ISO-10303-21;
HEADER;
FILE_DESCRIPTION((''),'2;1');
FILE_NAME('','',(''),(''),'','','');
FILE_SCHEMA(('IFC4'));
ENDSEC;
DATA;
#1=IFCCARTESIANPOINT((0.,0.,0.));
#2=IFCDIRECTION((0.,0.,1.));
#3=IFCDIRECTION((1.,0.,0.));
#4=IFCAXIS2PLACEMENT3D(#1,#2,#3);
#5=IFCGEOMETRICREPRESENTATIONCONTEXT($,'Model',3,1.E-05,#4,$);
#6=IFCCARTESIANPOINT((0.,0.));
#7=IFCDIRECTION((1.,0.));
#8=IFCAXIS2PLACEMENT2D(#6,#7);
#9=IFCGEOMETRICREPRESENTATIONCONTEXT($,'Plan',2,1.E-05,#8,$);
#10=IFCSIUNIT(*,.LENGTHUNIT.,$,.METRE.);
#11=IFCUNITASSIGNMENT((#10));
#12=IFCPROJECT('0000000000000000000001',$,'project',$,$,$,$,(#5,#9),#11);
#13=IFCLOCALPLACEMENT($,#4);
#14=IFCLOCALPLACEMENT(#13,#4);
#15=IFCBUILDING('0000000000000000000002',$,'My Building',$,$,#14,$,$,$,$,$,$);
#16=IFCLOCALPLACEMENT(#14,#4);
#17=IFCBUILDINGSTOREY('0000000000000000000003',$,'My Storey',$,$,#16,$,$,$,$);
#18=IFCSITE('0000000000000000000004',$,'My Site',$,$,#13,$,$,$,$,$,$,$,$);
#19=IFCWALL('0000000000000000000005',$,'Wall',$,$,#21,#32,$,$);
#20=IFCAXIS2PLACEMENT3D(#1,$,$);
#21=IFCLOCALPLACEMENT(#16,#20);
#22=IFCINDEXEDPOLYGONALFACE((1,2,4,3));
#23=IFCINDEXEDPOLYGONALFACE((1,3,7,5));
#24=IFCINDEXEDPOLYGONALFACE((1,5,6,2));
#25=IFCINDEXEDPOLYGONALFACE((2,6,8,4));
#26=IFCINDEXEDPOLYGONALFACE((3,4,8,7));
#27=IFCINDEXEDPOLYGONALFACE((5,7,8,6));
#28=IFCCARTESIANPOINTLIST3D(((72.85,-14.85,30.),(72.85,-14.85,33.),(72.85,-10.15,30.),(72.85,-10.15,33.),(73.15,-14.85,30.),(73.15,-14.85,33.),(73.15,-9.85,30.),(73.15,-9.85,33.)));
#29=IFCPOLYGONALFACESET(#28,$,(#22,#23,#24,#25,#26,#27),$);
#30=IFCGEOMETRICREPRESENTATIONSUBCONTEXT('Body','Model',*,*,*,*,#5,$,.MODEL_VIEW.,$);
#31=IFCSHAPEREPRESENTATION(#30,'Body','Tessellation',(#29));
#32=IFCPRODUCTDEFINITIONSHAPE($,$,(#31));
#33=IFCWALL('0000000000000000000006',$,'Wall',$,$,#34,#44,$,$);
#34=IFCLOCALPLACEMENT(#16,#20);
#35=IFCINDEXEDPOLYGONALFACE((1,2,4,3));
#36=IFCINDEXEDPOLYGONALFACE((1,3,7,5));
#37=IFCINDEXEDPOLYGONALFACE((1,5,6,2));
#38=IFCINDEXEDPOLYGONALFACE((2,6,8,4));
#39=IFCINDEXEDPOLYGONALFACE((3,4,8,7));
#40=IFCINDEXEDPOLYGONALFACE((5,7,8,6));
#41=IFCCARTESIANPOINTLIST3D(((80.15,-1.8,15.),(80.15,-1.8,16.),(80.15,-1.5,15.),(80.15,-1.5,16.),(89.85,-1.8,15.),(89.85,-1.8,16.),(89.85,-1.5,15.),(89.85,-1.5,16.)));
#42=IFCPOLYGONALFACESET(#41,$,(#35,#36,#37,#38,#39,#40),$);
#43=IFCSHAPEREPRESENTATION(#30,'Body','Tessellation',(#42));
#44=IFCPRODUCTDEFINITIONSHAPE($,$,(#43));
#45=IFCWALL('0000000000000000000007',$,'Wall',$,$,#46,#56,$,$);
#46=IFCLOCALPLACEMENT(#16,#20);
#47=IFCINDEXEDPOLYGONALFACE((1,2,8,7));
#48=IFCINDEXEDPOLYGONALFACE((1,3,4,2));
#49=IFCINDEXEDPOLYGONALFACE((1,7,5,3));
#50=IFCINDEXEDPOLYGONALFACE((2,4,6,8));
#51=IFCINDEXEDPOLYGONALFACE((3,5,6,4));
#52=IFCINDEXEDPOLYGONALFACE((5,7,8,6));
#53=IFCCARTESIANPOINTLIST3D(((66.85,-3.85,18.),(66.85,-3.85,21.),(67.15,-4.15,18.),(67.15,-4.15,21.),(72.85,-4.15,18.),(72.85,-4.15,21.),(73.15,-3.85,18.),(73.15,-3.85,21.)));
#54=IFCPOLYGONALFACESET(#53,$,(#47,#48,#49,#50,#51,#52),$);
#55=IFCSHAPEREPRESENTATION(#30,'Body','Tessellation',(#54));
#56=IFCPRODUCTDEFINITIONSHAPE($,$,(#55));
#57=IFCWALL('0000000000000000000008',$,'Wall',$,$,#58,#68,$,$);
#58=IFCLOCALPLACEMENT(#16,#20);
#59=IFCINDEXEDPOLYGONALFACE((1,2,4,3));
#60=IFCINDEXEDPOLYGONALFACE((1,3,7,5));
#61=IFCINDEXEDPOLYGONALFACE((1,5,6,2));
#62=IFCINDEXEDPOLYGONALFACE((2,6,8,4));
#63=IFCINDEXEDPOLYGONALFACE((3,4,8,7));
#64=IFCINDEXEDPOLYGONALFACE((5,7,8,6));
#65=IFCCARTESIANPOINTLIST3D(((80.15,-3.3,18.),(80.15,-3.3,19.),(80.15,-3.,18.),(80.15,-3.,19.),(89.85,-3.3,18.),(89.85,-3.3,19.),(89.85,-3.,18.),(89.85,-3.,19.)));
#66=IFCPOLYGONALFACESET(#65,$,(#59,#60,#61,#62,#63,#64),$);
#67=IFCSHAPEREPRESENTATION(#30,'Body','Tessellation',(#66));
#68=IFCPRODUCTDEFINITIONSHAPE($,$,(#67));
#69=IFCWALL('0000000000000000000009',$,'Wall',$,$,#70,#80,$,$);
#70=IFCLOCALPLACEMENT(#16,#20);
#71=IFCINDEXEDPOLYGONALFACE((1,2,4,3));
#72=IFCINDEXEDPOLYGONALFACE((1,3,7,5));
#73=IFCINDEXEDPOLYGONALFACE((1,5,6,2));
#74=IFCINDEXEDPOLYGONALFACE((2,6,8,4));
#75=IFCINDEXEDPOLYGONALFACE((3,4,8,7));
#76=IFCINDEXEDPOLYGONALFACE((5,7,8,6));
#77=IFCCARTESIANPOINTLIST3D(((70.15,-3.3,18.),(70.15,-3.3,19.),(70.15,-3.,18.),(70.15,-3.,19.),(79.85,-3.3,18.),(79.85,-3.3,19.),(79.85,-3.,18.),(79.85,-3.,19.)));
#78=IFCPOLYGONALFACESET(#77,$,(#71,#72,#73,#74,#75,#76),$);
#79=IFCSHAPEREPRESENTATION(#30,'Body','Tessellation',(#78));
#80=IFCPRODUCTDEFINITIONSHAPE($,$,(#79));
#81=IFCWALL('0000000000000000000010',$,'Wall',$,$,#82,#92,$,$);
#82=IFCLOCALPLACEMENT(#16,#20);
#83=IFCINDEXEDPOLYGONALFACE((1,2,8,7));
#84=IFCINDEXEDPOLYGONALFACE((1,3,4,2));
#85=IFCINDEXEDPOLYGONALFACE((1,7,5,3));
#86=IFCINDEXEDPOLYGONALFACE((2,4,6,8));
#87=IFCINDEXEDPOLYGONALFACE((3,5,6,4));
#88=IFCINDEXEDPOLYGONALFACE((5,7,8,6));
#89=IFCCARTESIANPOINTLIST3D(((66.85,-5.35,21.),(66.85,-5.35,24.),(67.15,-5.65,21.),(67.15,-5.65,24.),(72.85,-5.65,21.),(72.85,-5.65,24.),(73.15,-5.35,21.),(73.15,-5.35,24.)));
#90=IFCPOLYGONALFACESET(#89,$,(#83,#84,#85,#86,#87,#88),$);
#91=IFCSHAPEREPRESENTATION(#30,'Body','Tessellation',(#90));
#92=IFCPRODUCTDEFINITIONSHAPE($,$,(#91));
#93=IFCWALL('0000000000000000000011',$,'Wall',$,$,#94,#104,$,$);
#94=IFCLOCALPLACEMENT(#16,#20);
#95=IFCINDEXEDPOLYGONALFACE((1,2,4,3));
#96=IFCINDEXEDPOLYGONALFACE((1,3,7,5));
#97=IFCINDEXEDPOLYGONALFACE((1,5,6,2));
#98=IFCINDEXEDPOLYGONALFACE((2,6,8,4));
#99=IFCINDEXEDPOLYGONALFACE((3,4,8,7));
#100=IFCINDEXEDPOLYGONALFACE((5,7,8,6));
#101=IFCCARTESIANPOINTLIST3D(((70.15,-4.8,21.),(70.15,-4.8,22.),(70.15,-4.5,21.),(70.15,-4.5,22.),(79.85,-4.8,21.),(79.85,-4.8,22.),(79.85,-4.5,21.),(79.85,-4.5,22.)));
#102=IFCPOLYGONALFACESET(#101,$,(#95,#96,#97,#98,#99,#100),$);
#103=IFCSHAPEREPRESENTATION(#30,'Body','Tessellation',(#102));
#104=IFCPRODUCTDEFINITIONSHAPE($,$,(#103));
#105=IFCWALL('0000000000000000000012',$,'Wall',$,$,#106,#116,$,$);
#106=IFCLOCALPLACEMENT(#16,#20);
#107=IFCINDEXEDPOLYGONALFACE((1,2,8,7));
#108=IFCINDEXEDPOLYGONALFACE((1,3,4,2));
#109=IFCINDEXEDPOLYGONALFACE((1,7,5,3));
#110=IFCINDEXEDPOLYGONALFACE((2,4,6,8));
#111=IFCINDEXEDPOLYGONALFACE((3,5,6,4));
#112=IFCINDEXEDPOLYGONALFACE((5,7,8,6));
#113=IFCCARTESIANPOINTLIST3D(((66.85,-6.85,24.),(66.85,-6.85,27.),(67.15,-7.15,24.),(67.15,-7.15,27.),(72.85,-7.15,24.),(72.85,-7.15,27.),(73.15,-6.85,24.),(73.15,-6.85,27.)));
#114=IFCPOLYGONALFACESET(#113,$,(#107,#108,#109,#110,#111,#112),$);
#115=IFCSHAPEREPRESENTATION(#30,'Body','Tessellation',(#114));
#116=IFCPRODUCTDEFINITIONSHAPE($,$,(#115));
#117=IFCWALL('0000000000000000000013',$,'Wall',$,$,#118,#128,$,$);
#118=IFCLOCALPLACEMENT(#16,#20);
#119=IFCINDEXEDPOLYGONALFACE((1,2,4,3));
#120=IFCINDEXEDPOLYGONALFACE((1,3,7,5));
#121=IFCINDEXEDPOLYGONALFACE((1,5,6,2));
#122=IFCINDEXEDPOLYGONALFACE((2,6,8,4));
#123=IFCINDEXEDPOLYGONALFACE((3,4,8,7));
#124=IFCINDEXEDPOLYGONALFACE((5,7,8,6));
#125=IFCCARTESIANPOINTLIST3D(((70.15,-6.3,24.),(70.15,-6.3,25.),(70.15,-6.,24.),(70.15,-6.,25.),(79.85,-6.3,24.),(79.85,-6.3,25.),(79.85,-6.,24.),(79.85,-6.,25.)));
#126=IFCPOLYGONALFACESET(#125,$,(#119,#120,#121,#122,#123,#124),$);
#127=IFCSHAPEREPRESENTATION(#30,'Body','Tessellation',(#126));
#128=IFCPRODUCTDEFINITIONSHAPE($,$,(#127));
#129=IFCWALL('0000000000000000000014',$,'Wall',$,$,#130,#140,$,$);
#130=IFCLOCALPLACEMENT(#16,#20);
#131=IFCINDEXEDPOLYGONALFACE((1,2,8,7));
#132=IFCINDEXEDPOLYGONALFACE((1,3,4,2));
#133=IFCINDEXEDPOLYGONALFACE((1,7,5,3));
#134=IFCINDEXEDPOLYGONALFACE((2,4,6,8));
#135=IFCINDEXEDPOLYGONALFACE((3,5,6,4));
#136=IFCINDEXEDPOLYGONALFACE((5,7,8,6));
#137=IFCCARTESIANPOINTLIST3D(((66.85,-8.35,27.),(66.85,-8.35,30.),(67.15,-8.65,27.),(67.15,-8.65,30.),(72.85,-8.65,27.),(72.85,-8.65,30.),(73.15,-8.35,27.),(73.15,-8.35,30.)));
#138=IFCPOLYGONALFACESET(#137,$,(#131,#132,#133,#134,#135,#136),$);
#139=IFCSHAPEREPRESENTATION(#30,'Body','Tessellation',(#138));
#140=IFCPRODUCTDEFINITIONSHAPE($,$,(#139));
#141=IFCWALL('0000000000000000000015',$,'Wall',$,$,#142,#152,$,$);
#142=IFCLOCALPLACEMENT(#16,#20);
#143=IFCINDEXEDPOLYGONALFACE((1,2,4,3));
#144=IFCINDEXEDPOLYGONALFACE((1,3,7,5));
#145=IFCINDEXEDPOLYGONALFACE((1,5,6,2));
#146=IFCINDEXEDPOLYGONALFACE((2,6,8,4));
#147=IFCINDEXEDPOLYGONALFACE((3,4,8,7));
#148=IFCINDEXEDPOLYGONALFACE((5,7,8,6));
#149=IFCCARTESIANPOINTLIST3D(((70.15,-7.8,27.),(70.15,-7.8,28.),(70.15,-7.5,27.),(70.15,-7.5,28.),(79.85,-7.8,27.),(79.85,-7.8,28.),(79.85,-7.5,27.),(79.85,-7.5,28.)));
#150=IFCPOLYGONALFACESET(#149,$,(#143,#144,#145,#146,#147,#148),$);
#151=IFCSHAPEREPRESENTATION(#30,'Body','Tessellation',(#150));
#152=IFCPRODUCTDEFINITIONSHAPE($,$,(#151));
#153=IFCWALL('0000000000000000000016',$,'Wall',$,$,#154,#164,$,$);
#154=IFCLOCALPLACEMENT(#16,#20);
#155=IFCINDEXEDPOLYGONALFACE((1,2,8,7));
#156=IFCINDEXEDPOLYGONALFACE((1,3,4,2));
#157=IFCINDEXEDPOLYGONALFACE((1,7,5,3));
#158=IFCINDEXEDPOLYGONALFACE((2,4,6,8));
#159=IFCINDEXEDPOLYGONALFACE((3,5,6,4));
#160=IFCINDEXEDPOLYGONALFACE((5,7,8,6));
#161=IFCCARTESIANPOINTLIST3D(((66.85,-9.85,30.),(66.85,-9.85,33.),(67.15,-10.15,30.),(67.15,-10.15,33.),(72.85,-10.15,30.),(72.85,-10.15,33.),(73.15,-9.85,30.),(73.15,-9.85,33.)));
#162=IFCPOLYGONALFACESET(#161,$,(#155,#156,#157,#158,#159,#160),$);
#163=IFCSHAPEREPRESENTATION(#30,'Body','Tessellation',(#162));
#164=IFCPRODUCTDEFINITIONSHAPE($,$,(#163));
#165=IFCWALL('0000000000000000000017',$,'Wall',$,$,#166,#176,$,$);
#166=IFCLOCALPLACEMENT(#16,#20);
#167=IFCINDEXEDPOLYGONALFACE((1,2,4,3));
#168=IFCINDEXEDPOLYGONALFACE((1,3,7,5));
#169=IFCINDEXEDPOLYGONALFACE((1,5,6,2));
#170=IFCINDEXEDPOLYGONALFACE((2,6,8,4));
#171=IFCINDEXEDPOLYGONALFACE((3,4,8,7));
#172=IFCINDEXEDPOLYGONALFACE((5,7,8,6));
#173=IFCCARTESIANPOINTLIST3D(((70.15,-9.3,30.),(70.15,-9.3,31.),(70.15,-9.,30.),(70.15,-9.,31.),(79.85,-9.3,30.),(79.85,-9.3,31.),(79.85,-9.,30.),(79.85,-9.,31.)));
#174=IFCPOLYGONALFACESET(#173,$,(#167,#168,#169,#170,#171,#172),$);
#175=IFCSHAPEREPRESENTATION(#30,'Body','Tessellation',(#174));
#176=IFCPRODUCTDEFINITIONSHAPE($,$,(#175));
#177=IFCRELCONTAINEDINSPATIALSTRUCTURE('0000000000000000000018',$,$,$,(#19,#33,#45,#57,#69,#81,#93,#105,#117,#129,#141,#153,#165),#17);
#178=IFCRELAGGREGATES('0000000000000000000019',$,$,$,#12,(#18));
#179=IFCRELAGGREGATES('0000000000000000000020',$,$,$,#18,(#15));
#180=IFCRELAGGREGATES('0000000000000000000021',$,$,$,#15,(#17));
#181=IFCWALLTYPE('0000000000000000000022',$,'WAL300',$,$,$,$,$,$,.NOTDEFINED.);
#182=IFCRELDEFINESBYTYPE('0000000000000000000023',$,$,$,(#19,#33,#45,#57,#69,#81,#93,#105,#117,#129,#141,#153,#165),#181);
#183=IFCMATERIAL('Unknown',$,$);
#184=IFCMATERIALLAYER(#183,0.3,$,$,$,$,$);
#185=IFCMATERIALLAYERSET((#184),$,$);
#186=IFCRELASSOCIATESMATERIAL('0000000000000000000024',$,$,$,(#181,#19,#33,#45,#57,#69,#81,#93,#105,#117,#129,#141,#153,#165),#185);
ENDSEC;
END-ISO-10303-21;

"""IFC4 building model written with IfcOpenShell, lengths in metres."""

from ifc_helpers import new_model, si_unit, frame, origin_with_axes, origin_2d_with_axis, place, context, subcontext, project, spatial, line, indexed_curve, outline, extrude, material, layer, layer_set, layer_usage, type_object, element, save


model = new_model("IFC4")

# Units and contexts
model_context = context("Model", 3, precision=1e-05, world=origin_with_axes())
plan_context = context("Plan", 2, precision=1e-05, world=origin_2d_with_axis())
body_context = subcontext(model_context, "Body", "Model", "MODEL_VIEW")
ifc_project = project(units=[si_unit("LENGTHUNIT", "METRE")], contexts=[model_context, plan_context])

# Site, building, storey
site_placement = place(None, origin_with_axes())
site = spatial("IfcSite", under=ifc_project, at=site_placement, Name="My Site")
building_placement = place(site_placement, origin_with_axes())
building = spatial("IfcBuilding", under=site, at=building_placement, Name="My Building")
storey_placement = place(building_placement, origin_with_axes())
storey = spatial("IfcBuildingStorey", under=building, at=storey_placement, Name="My Storey")

# Walls
ifc_material = material(Name="Unknown")
ifc_layer = layer(ifc_material, 0.3)
ifc_layer_set = layer_set([ifc_layer])
wall_type = type_object("IfcWallType", Name="WAL300", PredefinedType="NOTDEFINED", material=ifc_layer_set)
ifc_layer_usage_1 = layer_usage(ifc_layer_set, "AXIS2", "POSITIVE", -0.15)
wall_1_placement = place(storey_placement, frame((73.0, -15.0, 30.0), z_axis=(0.0, 0.0, 1.0), x_axis=(0.0, 1.0, 0.0)))
element("IfcWall", 1, at=wall_1_placement, inside=storey, type_object=wall_type, material=ifc_layer_usage_1, Name="Wall", context=body_context, shape_type="SweptSolid", body=[
    extrude(outline(indexed_curve([(0.15, -0.15), (0.15, 0.15), (4.85, 0.15), (5.15, -0.15)], segments=[line(1, 2, 3, 4, 1)])), origin_with_axes(), (0.0, 0.0, 1.0), 3.0),
])
ifc_layer_usage_2 = layer_usage(ifc_layer_set, "AXIS2", "POSITIVE", -0.3)
wall_2_placement = place(storey_placement, frame((80.15, -1.5, 15.0), z_axis=(0.0, 0.0, 1.0), x_axis=(1.0, 0.0, 0.0)))
element("IfcWall", 2, at=wall_2_placement, inside=storey, type_object=wall_type, material=ifc_layer_usage_2, Name="Wall", context=body_context, shape_type="SweptSolid", body=[
    extrude(outline(indexed_curve([(0.0, -0.3), (0.0, 0.0), (9.7, 0.0), (9.7, -0.3)], segments=[line(1, 2, 3, 4, 1)])), origin_with_axes(), (0.0, 0.0, 1.0), 1.0),
])
ifc_layer_usage_3 = layer_usage(ifc_layer_set, "AXIS2", "POSITIVE", -0.15)
wall_3_placement = place(storey_placement, frame((67.0, -4.0, 18.0), z_axis=(0.0, 0.0, 1.0), x_axis=(1.0, 0.0, 0.0)))
element("IfcWall", 3, at=wall_3_placement, inside=storey, type_object=wall_type, material=ifc_layer_usage_3, Name="Wall", context=body_context, shape_type="SweptSolid", body=[
    extrude(outline(indexed_curve([(0.15, -0.15), (-0.15, 0.15), (6.15, 0.15), (5.85, -0.15)], segments=[line(1, 2, 3, 4, 1)])), origin_with_axes(), (0.0, 0.0, 1.0), 3.0),
])
ifc_layer_usage_4 = layer_usage(ifc_layer_set, "AXIS2", "POSITIVE", -0.3)
wall_4_placement = place(storey_placement, frame((80.15, -3.0, 18.0), z_axis=(0.0, 0.0, 1.0), x_axis=(1.0, 0.0, 0.0)))
element("IfcWall", 4, at=wall_4_placement, inside=storey, type_object=wall_type, material=ifc_layer_usage_4, Name="Wall", context=body_context, shape_type="SweptSolid", body=[
    extrude(outline(indexed_curve([(0.0, -0.3), (0.0, 0.0), (9.7, 0.0), (9.7, -0.3)], segments=[line(1, 2, 3, 4, 1)])), origin_with_axes(), (0.0, 0.0, 1.0), 1.0),
])
ifc_layer_usage_5 = layer_usage(ifc_layer_set, "AXIS2", "POSITIVE", -0.3)
wall_5_placement = place(storey_placement, frame((70.15, -3.0, 18.0), z_axis=(0.0, 0.0, 1.0), x_axis=(1.0, 0.0, 0.0)))
element("IfcWall", 5, at=wall_5_placement, inside=storey, type_object=wall_type, material=ifc_layer_usage_5, Name="Wall", context=body_context, shape_type="SweptSolid", body=[
    extrude(outline(indexed_curve([(0.0, -0.3), (0.0, 0.0), (9.7, 0.0), (9.7, -0.3)], segments=[line(1, 2, 3, 4, 1)])), origin_with_axes(), (0.0, 0.0, 1.0), 1.0),
])
ifc_layer_usage_6 = layer_usage(ifc_layer_set, "AXIS2", "POSITIVE", -0.15)
wall_6_placement = place(storey_placement, frame((67.0, -5.5, 21.0), z_axis=(0.0, 0.0, 1.0), x_axis=(1.0, 0.0, 0.0)))
element("IfcWall", 6, at=wall_6_placement, inside=storey, type_object=wall_type, material=ifc_layer_usage_6, Name="Wall", context=body_context, shape_type="SweptSolid", body=[
    extrude(outline(indexed_curve([(0.15, -0.15), (-0.15, 0.15), (6.15, 0.15), (5.85, -0.15)], segments=[line(1, 2, 3, 4, 1)])), origin_with_axes(), (0.0, 0.0, 1.0), 3.0),
])
ifc_layer_usage_7 = layer_usage(ifc_layer_set, "AXIS2", "POSITIVE", -0.3)
wall_7_placement = place(storey_placement, frame((70.15, -4.5, 21.0), z_axis=(0.0, 0.0, 1.0), x_axis=(1.0, 0.0, 0.0)))
element("IfcWall", 7, at=wall_7_placement, inside=storey, type_object=wall_type, material=ifc_layer_usage_7, Name="Wall", context=body_context, shape_type="SweptSolid", body=[
    extrude(outline(indexed_curve([(0.0, -0.3), (0.0, 0.0), (9.7, 0.0), (9.7, -0.3)], segments=[line(1, 2, 3, 4, 1)])), origin_with_axes(), (0.0, 0.0, 1.0), 1.0),
])
ifc_layer_usage_8 = layer_usage(ifc_layer_set, "AXIS2", "POSITIVE", -0.15)
wall_8_placement = place(storey_placement, frame((67.0, -7.0, 24.0), z_axis=(0.0, 0.0, 1.0), x_axis=(1.0, 0.0, 0.0)))
element("IfcWall", 8, at=wall_8_placement, inside=storey, type_object=wall_type, material=ifc_layer_usage_8, Name="Wall", context=body_context, shape_type="SweptSolid", body=[
    extrude(outline(indexed_curve([(0.15, -0.15), (-0.15, 0.15), (6.15, 0.15), (5.85, -0.15)], segments=[line(1, 2, 3, 4, 1)])), origin_with_axes(), (0.0, 0.0, 1.0), 3.0),
])
ifc_layer_usage_9 = layer_usage(ifc_layer_set, "AXIS2", "POSITIVE", -0.3)
wall_9_placement = place(storey_placement, frame((70.15, -6.0, 24.0), z_axis=(0.0, 0.0, 1.0), x_axis=(1.0, 0.0, 0.0)))
element("IfcWall", 9, at=wall_9_placement, inside=storey, type_object=wall_type, material=ifc_layer_usage_9, Name="Wall", context=body_context, shape_type="SweptSolid", body=[
    extrude(outline(indexed_curve([(0.0, -0.3), (0.0, 0.0), (9.7, 0.0), (9.7, -0.3)], segments=[line(1, 2, 3, 4, 1)])), origin_with_axes(), (0.0, 0.0, 1.0), 1.0),
])
ifc_layer_usage_10 = layer_usage(ifc_layer_set, "AXIS2", "POSITIVE", -0.15)
wall_10_placement = place(storey_placement, frame((67.0, -8.5, 27.0), z_axis=(0.0, 0.0, 1.0), x_axis=(1.0, 0.0, 0.0)))
element("IfcWall", 10, at=wall_10_placement, inside=storey, type_object=wall_type, material=ifc_layer_usage_10, Name="Wall", context=body_context, shape_type="SweptSolid", body=[
    extrude(outline(indexed_curve([(0.15, -0.15), (-0.15, 0.15), (6.15, 0.15), (5.85, -0.15)], segments=[line(1, 2, 3, 4, 1)])), origin_with_axes(), (0.0, 0.0, 1.0), 3.0),
])
ifc_layer_usage_11 = layer_usage(ifc_layer_set, "AXIS2", "POSITIVE", -0.3)
wall_11_placement = place(storey_placement, frame((70.15, -7.5, 27.0), z_axis=(0.0, 0.0, 1.0), x_axis=(1.0, 0.0, 0.0)))
element("IfcWall", 11, at=wall_11_placement, inside=storey, type_object=wall_type, material=ifc_layer_usage_11, Name="Wall", context=body_context, shape_type="SweptSolid", body=[
    extrude(outline(indexed_curve([(0.0, -0.3), (0.0, 0.0), (9.7, 0.0), (9.7, -0.3)], segments=[line(1, 2, 3, 4, 1)])), origin_with_axes(), (0.0, 0.0, 1.0), 1.0),
])
ifc_layer_usage_12 = layer_usage(ifc_layer_set, "AXIS2", "POSITIVE", -0.15)
wall_12_placement = place(storey_placement, frame((67.0, -10.0, 30.0), z_axis=(0.0, 0.0, 1.0), x_axis=(1.0, 0.0, 0.0)))
element("IfcWall", 12, at=wall_12_placement, inside=storey, type_object=wall_type, material=ifc_layer_usage_12, Name="Wall", context=body_context, shape_type="SweptSolid", body=[
    extrude(outline(indexed_curve([(0.15, -0.15), (-0.15, 0.15), (6.15, 0.15), (5.85, -0.15)], segments=[line(1, 2, 3, 4, 1)])), origin_with_axes(), (0.0, 0.0, 1.0), 3.0),
])
ifc_layer_usage_13 = layer_usage(ifc_layer_set, "AXIS2", "POSITIVE", -0.3)
wall_13_placement = place(storey_placement, frame((70.15, -9.0, 30.0), z_axis=(0.0, 0.0, 1.0), x_axis=(1.0, 0.0, 0.0)))
element("IfcWall", 13, at=wall_13_placement, inside=storey, type_object=wall_type, material=ifc_layer_usage_13, Name="Wall", context=body_context, shape_type="SweptSolid", body=[
    extrude(outline(indexed_curve([(0.0, -0.3), (0.0, 0.0), (9.7, 0.0), (9.7, -0.3)], segments=[line(1, 2, 3, 4, 1)])), origin_with_axes(), (0.0, 0.0, 1.0), 1.0),
])

save(model, "model.ifc")
